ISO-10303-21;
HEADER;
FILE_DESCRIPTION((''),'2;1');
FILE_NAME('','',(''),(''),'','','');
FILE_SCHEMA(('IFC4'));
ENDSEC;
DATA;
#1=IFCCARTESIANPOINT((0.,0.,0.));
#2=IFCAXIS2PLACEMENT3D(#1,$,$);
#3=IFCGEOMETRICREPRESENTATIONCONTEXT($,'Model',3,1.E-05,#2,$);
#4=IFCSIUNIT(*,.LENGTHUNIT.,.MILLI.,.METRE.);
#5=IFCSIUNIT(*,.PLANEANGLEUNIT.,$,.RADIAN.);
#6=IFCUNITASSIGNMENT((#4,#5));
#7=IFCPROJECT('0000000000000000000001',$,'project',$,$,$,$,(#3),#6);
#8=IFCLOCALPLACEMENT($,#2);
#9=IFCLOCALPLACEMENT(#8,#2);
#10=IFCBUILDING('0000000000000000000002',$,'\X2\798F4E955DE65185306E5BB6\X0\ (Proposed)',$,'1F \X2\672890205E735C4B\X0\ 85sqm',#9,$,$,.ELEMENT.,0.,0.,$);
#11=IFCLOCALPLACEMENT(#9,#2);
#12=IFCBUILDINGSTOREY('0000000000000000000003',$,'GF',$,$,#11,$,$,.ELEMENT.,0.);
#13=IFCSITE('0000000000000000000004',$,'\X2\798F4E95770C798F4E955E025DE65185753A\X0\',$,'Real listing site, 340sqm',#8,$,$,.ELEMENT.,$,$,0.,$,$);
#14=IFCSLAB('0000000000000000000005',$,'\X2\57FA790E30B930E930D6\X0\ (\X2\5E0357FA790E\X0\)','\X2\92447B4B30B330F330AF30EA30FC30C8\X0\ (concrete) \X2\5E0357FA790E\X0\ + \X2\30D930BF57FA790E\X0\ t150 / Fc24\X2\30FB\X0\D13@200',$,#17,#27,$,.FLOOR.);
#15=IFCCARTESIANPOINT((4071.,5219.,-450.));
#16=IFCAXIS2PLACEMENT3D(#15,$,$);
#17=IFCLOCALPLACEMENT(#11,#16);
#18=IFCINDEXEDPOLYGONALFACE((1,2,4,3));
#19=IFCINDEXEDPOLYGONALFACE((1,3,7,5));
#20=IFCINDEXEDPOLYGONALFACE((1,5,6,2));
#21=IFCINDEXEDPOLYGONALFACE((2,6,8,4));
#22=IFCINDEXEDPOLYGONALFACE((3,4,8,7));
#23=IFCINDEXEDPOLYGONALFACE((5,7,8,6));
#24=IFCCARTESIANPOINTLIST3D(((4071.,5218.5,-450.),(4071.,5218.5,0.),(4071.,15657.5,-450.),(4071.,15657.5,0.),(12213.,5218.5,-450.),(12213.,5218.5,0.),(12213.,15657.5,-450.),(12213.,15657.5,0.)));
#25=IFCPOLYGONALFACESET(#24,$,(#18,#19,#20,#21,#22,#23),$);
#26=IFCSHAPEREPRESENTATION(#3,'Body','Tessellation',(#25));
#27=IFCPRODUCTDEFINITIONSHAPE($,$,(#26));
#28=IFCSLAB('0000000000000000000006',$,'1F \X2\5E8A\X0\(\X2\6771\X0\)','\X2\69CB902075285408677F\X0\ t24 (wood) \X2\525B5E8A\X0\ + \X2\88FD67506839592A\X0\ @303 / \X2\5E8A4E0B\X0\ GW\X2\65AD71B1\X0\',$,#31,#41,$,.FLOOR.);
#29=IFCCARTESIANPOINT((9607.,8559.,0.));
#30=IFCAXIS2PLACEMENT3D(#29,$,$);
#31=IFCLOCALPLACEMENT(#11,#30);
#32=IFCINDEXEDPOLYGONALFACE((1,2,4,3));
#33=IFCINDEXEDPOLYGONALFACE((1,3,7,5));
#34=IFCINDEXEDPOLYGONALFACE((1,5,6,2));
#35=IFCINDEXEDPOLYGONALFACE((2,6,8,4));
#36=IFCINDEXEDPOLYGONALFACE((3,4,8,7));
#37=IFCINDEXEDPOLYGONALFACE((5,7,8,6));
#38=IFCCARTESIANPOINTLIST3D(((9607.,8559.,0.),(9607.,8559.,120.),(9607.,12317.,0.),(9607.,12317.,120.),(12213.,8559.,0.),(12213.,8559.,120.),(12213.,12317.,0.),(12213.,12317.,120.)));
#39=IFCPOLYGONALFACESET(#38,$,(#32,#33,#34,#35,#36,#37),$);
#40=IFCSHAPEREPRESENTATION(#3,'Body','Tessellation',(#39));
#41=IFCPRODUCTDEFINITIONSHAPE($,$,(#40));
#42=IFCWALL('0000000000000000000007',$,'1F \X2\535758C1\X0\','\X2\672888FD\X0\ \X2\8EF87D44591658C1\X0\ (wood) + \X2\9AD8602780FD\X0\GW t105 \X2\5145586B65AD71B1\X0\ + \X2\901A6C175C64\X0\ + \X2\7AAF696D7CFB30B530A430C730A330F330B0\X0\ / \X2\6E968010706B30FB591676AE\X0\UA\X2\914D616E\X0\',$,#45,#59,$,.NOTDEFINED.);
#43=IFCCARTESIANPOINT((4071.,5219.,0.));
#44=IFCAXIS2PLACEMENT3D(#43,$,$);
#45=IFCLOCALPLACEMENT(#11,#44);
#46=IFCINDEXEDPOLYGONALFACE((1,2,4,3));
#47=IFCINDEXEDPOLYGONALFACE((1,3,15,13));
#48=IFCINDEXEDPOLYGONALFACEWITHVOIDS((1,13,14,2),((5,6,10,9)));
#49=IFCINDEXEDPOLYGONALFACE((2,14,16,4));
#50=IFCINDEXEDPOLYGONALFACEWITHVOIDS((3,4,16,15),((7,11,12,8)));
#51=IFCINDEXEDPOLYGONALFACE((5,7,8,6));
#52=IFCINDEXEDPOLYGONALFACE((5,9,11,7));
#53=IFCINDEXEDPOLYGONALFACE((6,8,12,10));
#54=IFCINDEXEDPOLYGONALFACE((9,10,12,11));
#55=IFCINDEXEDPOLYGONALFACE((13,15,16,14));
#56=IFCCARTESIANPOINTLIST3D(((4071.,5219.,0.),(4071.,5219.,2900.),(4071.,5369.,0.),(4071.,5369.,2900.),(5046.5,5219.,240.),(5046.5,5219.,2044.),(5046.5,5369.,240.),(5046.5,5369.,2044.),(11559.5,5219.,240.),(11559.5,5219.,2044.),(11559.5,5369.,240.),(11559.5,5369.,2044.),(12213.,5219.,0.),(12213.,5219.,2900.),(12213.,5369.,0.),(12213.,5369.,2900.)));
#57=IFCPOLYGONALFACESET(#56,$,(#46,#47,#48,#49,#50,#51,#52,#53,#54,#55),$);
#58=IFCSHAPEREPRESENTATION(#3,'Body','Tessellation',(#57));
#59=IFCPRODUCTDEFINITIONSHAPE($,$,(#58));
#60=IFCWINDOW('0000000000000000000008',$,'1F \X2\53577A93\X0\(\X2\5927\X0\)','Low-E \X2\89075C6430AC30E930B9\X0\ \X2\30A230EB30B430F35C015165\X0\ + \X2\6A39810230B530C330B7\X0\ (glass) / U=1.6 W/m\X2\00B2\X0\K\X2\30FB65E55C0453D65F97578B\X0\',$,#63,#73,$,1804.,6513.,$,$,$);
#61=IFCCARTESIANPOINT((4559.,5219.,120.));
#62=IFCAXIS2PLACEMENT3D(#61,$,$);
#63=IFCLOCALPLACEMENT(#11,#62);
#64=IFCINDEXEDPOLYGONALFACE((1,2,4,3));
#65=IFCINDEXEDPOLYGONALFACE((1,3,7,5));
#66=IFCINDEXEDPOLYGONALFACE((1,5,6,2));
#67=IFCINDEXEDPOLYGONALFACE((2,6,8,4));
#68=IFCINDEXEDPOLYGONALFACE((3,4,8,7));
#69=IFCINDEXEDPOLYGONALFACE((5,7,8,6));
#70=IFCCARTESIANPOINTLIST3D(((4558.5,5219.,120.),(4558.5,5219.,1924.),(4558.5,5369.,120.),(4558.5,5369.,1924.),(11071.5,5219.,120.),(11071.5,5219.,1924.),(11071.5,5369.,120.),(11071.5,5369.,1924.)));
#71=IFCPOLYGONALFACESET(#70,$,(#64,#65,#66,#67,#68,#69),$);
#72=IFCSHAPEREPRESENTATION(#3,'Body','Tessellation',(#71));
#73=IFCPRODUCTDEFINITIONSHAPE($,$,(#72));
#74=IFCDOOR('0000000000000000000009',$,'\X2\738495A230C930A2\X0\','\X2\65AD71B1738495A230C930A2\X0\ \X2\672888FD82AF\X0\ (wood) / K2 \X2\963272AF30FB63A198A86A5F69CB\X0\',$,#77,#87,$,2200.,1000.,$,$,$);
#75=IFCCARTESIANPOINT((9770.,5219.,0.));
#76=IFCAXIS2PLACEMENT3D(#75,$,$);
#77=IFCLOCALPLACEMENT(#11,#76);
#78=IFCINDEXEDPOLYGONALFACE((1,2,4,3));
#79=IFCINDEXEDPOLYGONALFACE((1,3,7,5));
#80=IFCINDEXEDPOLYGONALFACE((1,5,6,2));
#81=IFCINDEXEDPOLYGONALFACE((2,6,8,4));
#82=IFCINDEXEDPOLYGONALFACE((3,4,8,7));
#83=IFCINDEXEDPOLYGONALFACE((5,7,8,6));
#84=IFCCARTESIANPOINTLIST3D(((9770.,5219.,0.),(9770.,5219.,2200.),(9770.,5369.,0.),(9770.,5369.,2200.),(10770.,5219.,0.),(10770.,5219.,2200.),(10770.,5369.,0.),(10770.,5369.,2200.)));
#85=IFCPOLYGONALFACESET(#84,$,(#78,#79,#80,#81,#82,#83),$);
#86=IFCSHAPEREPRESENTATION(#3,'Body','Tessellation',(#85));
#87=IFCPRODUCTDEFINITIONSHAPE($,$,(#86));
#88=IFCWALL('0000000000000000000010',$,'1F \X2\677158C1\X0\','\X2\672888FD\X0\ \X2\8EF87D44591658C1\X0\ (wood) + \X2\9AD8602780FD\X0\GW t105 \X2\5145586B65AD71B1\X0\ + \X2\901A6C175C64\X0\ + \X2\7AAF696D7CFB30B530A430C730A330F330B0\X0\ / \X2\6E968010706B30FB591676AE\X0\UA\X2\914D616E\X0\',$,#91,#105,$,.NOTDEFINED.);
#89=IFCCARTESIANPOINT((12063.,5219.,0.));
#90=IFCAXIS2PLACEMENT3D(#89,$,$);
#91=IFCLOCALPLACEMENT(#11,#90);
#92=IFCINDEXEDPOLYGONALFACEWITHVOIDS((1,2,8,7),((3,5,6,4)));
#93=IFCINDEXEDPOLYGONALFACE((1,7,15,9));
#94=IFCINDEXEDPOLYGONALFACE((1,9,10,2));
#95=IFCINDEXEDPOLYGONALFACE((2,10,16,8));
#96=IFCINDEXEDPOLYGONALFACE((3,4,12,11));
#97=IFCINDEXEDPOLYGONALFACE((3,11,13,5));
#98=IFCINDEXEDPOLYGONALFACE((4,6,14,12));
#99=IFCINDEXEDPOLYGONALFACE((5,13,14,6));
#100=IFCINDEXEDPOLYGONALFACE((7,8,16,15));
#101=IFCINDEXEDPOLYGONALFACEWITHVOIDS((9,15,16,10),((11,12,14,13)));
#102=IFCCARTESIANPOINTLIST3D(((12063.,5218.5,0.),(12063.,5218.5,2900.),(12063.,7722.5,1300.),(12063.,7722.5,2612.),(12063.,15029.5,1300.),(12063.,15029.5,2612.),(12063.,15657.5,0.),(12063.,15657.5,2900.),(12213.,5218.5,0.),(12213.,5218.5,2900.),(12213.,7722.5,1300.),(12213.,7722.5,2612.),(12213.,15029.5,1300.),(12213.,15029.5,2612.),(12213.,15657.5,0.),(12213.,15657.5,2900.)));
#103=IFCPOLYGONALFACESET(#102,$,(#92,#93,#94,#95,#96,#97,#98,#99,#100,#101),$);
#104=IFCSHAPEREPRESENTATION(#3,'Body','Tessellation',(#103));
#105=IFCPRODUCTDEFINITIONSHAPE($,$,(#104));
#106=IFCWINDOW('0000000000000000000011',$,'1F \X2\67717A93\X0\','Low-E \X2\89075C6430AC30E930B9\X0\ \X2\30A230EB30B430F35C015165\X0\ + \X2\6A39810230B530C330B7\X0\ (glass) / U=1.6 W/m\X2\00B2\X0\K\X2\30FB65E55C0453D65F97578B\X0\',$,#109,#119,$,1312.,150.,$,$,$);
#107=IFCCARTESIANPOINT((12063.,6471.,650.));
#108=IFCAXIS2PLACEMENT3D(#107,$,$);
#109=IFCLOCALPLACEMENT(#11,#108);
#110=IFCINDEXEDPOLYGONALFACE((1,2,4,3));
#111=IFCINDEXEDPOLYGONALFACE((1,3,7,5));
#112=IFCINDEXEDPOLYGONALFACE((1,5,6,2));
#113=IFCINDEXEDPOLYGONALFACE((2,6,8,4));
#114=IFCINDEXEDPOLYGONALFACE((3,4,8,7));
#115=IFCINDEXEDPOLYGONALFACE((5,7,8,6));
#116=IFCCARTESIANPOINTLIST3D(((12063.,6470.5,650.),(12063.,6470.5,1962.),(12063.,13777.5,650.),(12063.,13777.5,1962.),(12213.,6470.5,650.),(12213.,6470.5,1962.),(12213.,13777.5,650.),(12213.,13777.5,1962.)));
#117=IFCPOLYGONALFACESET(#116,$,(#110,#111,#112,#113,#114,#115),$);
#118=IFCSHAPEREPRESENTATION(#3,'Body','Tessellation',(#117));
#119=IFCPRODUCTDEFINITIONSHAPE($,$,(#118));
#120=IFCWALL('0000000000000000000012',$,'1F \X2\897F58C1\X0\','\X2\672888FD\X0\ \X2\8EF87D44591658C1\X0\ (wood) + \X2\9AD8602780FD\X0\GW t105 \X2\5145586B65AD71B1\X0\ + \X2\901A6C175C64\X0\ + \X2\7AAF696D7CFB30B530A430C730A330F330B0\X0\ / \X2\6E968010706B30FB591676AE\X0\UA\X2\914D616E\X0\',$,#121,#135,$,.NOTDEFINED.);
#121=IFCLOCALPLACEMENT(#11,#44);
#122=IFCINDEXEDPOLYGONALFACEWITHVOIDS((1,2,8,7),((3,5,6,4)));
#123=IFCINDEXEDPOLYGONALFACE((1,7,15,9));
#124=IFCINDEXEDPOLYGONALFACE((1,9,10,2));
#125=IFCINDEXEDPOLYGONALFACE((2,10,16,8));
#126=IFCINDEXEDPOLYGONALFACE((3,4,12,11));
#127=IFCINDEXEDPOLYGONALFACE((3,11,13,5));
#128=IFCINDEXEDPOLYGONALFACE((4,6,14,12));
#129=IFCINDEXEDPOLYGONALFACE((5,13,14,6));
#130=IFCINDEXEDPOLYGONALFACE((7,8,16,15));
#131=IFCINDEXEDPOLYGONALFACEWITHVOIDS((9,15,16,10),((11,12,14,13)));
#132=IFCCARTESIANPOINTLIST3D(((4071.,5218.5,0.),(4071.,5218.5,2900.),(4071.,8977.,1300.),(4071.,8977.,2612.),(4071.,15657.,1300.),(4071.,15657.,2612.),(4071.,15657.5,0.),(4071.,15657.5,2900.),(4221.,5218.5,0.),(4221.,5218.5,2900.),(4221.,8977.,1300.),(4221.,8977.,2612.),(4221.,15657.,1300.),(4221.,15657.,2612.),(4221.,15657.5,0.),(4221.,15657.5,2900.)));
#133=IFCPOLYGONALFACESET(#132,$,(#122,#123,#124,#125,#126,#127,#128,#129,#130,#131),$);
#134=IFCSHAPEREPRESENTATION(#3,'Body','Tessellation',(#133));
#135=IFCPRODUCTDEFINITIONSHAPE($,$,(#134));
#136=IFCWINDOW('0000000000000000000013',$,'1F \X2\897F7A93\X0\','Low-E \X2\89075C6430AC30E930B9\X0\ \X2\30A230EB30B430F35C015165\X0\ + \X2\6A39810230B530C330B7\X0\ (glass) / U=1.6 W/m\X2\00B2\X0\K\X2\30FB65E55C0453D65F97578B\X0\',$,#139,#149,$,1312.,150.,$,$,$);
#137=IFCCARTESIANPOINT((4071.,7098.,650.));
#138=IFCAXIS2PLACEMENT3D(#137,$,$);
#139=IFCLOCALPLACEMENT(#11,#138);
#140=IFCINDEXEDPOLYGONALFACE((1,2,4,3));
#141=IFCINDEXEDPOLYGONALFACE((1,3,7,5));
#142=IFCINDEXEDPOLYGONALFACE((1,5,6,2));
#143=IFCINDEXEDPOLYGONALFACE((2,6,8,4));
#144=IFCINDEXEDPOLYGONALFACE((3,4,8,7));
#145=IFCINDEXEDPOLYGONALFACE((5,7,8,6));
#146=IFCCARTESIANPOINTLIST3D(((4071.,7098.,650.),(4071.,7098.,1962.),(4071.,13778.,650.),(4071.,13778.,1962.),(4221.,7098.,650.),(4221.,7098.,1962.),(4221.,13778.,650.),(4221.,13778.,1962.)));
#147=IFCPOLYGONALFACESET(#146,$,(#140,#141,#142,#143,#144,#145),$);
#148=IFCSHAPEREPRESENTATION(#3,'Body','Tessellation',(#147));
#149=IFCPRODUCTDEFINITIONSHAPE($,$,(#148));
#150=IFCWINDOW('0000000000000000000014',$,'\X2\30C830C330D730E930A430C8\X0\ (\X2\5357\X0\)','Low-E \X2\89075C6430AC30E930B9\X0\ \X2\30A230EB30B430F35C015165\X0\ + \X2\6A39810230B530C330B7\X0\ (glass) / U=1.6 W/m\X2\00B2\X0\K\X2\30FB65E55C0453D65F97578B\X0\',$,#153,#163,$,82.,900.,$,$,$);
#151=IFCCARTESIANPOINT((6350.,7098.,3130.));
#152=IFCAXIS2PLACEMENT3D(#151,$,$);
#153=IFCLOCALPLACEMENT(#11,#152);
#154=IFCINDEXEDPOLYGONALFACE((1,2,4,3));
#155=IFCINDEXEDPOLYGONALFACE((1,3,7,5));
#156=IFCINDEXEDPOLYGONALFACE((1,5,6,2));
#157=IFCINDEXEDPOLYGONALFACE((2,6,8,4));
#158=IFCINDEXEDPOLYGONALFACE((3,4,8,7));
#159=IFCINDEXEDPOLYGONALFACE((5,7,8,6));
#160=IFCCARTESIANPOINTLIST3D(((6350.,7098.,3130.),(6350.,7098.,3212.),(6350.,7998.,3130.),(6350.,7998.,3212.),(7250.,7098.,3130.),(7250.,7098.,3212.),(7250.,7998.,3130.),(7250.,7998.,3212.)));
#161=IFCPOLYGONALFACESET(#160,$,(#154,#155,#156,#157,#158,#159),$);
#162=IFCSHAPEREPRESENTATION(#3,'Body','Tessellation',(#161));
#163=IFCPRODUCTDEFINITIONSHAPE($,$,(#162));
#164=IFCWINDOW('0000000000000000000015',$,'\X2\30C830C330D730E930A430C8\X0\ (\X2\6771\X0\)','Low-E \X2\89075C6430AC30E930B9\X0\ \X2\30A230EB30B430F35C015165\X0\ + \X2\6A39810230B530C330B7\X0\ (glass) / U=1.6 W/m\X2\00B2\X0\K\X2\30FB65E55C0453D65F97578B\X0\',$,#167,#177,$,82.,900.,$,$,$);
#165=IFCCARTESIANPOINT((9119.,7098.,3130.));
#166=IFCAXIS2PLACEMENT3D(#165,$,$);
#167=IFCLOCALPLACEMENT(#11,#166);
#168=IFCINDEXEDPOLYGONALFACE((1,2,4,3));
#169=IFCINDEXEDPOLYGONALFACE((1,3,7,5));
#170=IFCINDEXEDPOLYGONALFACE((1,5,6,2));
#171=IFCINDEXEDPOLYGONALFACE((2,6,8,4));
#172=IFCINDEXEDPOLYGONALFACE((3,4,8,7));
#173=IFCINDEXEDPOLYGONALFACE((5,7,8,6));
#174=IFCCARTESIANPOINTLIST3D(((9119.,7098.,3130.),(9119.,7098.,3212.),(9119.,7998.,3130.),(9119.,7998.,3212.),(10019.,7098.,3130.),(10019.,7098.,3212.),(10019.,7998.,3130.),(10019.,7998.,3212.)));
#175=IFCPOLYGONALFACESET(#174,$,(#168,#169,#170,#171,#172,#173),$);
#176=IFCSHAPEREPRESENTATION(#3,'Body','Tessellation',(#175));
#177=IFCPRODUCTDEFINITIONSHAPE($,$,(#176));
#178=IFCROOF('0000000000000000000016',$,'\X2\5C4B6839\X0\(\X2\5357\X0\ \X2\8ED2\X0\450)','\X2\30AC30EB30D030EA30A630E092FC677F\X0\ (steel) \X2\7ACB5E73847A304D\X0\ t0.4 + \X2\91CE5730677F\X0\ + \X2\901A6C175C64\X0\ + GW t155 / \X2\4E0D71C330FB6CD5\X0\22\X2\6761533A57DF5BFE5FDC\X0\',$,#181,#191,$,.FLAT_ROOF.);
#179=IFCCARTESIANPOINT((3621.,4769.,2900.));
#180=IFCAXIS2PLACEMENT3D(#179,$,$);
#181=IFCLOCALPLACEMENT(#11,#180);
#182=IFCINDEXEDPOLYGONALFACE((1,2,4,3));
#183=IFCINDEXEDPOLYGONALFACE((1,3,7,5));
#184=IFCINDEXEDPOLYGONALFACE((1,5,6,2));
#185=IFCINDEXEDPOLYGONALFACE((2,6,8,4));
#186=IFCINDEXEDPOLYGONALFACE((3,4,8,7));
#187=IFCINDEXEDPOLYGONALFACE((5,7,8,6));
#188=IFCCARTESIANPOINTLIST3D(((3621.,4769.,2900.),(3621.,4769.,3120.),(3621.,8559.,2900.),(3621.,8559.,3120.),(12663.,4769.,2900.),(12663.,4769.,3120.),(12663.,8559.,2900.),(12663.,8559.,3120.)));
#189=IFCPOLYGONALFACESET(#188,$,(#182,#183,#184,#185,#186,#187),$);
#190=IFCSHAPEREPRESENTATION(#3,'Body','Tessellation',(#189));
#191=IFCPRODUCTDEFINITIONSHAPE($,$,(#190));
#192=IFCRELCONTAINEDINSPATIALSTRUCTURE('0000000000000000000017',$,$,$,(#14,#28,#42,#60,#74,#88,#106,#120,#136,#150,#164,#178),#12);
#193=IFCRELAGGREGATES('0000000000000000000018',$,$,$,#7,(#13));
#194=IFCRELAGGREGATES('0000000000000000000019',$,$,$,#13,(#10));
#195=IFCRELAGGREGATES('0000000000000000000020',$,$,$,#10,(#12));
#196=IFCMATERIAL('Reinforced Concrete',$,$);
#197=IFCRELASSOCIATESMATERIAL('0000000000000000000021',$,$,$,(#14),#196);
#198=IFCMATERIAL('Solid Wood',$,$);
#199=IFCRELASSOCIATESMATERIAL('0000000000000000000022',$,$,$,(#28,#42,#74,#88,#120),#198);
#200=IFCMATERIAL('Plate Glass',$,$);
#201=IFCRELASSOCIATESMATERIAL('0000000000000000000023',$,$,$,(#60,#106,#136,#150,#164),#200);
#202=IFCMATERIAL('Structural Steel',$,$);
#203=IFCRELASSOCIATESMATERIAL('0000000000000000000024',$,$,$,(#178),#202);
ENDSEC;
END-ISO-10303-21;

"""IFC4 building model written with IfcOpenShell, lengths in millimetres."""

from ifc_helpers import new_model, si_unit, frame, frame_2d, origin, place, context, project, spatial, rectangle, extrude, material, element, fill, save


model = new_model("IFC4")

# Units and contexts
model_context = context("Model", 3, precision=1e-05, world=origin())
ifc_project = project(units=[si_unit("LENGTHUNIT", "METRE", prefix="MILLI"), si_unit("PLANEANGLEUNIT", "RADIAN")], contexts=[model_context])

# Site, building, storey
site_placement = place(None, origin())
site = spatial("IfcSite", under=ifc_project, at=site_placement, Name="福井県福井市左内町", ObjectType="Real listing site, 340sqm", CompositionType="ELEMENT", RefElevation=0.0)
building_placement = place(site_placement, origin())
building = spatial("IfcBuilding", under=site, at=building_placement, Name="福井左内の家 (Proposed)", ObjectType="1F 木造平屋 85sqm", CompositionType="ELEMENT", ElevationOfRefHeight=0.0, ElevationOfTerrain=0.0)
storey_placement = place(building_placement, origin())
storey = spatial("IfcBuildingStorey", under=building, at=storey_placement, Name="GF", CompositionType="ELEMENT", Elevation=0.0)

# Slabs
ifc_material_1 = material(Name="Reinforced Concrete")
slab_1_placement = place(storey_placement, frame((4071.0, 5219.0, -450.0)))
element("IfcSlab", 1, at=slab_1_placement, inside=storey, material=ifc_material_1, Name="基礎スラブ (布基礎)", Description="鉄筋コンクリート (concrete) 布基礎 + ベタ基礎 t150 / Fc24・D13@200", PredefinedType="FLOOR", context=model_context, shape_type="SweptSolid", body=[
    extrude(rectangle(XDim=8142.0, YDim=10439.0, at=frame_2d((4071.0, 5219.0))), frame((4071.0, 5219.0, -450.0)), (0.0, 0.0, 1.0), 450.0),
])
ifc_material_2 = material(Name="Solid Wood")
slab_2_placement = place(storey_placement, frame((9607.0, 8559.0, 0.0)))
element("IfcSlab", 2, at=slab_2_placement, inside=storey, material=ifc_material_2, Name="1F 床(東)", Description="構造用合板 t24 (wood) 剛床 + 製材根太 @303 / 床下 GW断熱", PredefinedType="FLOOR", context=model_context, shape_type="SweptSolid", body=[
    extrude(rectangle(XDim=2606.0, YDim=3758.0, at=frame_2d((1303.0, 1879.0))), frame((9607.0, 8559.0, 0.0)), (0.0, 0.0, 1.0), 120.0),
])

# Wall, openings, window, door
wall_1_placement = place(storey_placement, frame((4071.0, 5219.0, 0.0)))
wall_1 = element("IfcWall", 3, at=wall_1_placement, inside=storey, material=ifc_material_2, Name="1F 南壁", Description="木製 軸組外壁 (wood) + 高性能GW t105 充填断熱 + 通気層 + 窯業系サイディング / 準耐火・外皮UA配慮", PredefinedType="NOTDEFINED", context=model_context, shape_type="SweptSolid", body=[
    extrude(rectangle(XDim=8142.0, YDim=150.0, at=frame_2d((4071.0, 75.0))), frame((4071.0, 5219.0, 0.0)), (0.0, 0.0, 1.0), 2900.0),
])
opening_1_placement = place(storey_placement, frame((4559.0, 5219.0, 120.0)))
opening_1 = element("IfcOpeningElement", 4, at=opening_1_placement, cuts=wall_1, PredefinedType="NOTDEFINED", context=model_context, shape_type="SweptSolid", body=[
    extrude(rectangle(XDim=6513.0, YDim=150.0, at=frame_2d((3256.0, 75.0))), frame((4559.0, 5219.0, 120.0)), (0.0, 0.0, 1.0), 1804.0),
])
opening_2_placement = place(storey_placement, frame((9770.0, 5219.0, 0.0)))
opening_2 = element("IfcOpeningElement", 5, at=opening_2_placement, cuts=wall_1, PredefinedType="NOTDEFINED", context=model_context, shape_type="SweptSolid", body=[
    extrude(rectangle(XDim=1000.0, YDim=150.0, at=frame_2d((500.0, 75.0))), frame((9770.0, 5219.0, 0.0)), (0.0, 0.0, 1.0), 2200.0),
])
ifc_material_3 = material(Name="Plate Glass")
window_1_placement = place(storey_placement, frame((4559.0, 5219.0, 120.0)))
window_1 = element("IfcWindow", 6, at=window_1_placement, inside=storey, material=ifc_material_3, Name="1F 南窓(大)", Description="Low-E 複層ガラス アルゴン封入 + 樹脂サッシ (glass) / U=1.6 W/m²K・日射取得型", OverallHeight=1804.0, OverallWidth=6513.0, context=model_context, shape_type="SweptSolid", body=[
    extrude(rectangle(XDim=6513.0, YDim=150.0, at=frame_2d((3256.0, 75.0))), frame((4559.0, 5219.0, 120.0)), (0.0, 0.0, 1.0), 1804.0),
])
fill(opening_1, window_1)
door_placement = place(storey_placement, frame((9770.0, 5219.0, 0.0)))
door = element("IfcDoor", 7, at=door_placement, inside=storey, material=ifc_material_2, Name="玄関ドア", Description="断熱玄関ドア 木製芯 (wood) / K2 防犯・採風機構", OverallHeight=2200.0, OverallWidth=1000.0, context=model_context, shape_type="SweptSolid", body=[
    extrude(rectangle(XDim=1000.0, YDim=150.0, at=frame_2d((500.0, 75.0))), frame((9770.0, 5219.0, 0.0)), (0.0, 0.0, 1.0), 2200.0),
])
fill(opening_2, door)

# Walls, openings, windows
wall_2_placement = place(storey_placement, frame((12063.0, 5219.0, 0.0)))
wall_2 = element("IfcWall", 8, at=wall_2_placement, inside=storey, material=ifc_material_2, Name="1F 東壁", Description="木製 軸組外壁 (wood) + 高性能GW t105 充填断熱 + 通気層 + 窯業系サイディング / 準耐火・外皮UA配慮", PredefinedType="NOTDEFINED", context=model_context, shape_type="SweptSolid", body=[
    extrude(rectangle(XDim=150.0, YDim=10439.0, at=frame_2d((75.0, 5219.0))), frame((12063.0, 5219.0, 0.0)), (0.0, 0.0, 1.0), 2900.0),
])
opening_3_placement = place(storey_placement, frame((12063.0, 6471.0, 650.0)))
opening_3 = element("IfcOpeningElement", 9, at=opening_3_placement, cuts=wall_2, PredefinedType="NOTDEFINED", context=model_context, shape_type="SweptSolid", body=[
    extrude(rectangle(XDim=150.0, YDim=7307.0, at=frame_2d((75.0, 3653.0))), frame((12063.0, 6471.0, 650.0)), (0.0, 0.0, 1.0), 1312.0),
])
window_2_placement = place(storey_placement, frame((12063.0, 6471.0, 650.0)))
window_2 = element("IfcWindow", 10, at=window_2_placement, inside=storey, material=ifc_material_3, Name="1F 東窓", Description="Low-E 複層ガラス アルゴン封入 + 樹脂サッシ (glass) / U=1.6 W/m²K・日射取得型", OverallHeight=1312.0, OverallWidth=150.0, context=model_context, shape_type="SweptSolid", body=[
    extrude(rectangle(XDim=150.0, YDim=7307.0, at=frame_2d((75.0, 3653.0))), frame((12063.0, 6471.0, 650.0)), (0.0, 0.0, 1.0), 1312.0),
])
fill(opening_3, window_2)
wall_3_placement = place(storey_placement, frame((4071.0, 5219.0, 0.0)))
wall_3 = element("IfcWall", 11, at=wall_3_placement, inside=storey, material=ifc_material_2, Name="1F 西壁", Description="木製 軸組外壁 (wood) + 高性能GW t105 充填断熱 + 通気層 + 窯業系サイディング / 準耐火・外皮UA配慮", PredefinedType="NOTDEFINED", context=model_context, shape_type="SweptSolid", body=[
    extrude(rectangle(XDim=150.0, YDim=10439.0, at=frame_2d((75.0, 5219.0))), frame((4071.0, 5219.0, 0.0)), (0.0, 0.0, 1.0), 2900.0),
])
opening_4_placement = place(storey_placement, frame((4071.0, 7098.0, 650.0)))
opening_4 = element("IfcOpeningElement", 12, at=opening_4_placement, cuts=wall_3, PredefinedType="NOTDEFINED", context=model_context, shape_type="SweptSolid", body=[
    extrude(rectangle(XDim=150.0, YDim=6680.0, at=frame_2d((75.0, 3340.0))), frame((4071.0, 7098.0, 650.0)), (0.0, 0.0, 1.0), 1312.0),
])
window_3_placement = place(storey_placement, frame((4071.0, 7098.0, 650.0)))
window_3 = element("IfcWindow", 13, at=window_3_placement, inside=storey, material=ifc_material_3, Name="1F 西窓", Description="Low-E 複層ガラス アルゴン封入 + 樹脂サッシ (glass) / U=1.6 W/m²K・日射取得型", OverallHeight=1312.0, OverallWidth=150.0, context=model_context, shape_type="SweptSolid", body=[
    extrude(rectangle(XDim=150.0, YDim=6680.0, at=frame_2d((75.0, 3340.0))), frame((4071.0, 7098.0, 650.0)), (0.0, 0.0, 1.0), 1312.0),
])
fill(opening_4, window_3)

# Windows
window_4_placement = place(storey_placement, frame((6350.0, 7098.0, 3130.0)))
element("IfcWindow", 14, at=window_4_placement, inside=storey, material=ifc_material_3, Name="トップライト (南)", Description="Low-E 複層ガラス アルゴン封入 + 樹脂サッシ (glass) / U=1.6 W/m²K・日射取得型", OverallHeight=82.0, OverallWidth=900.0, context=model_context, shape_type="SweptSolid", body=[
    extrude(rectangle(XDim=900.0, YDim=900.0, at=frame_2d((450.0, 450.0))), frame((6350.0, 7098.0, 3130.0)), (0.0, 0.0, 1.0), 82.0),
])
window_5_placement = place(storey_placement, frame((9119.0, 7098.0, 3130.0)))
element("IfcWindow", 15, at=window_5_placement, inside=storey, material=ifc_material_3, Name="トップライト (東)", Description="Low-E 複層ガラス アルゴン封入 + 樹脂サッシ (glass) / U=1.6 W/m²K・日射取得型", OverallHeight=82.0, OverallWidth=900.0, context=model_context, shape_type="SweptSolid", body=[
    extrude(rectangle(XDim=900.0, YDim=900.0, at=frame_2d((450.0, 450.0))), frame((9119.0, 7098.0, 3130.0)), (0.0, 0.0, 1.0), 82.0),
])

# Roof
ifc_material_4 = material(Name="Structural Steel")
roof_placement = place(storey_placement, frame((3621.0, 4769.0, 2900.0)))
element("IfcRoof", 16, at=roof_placement, inside=storey, material=ifc_material_4, Name="屋根(南 軒450)", Description="ガルバリウム鋼板 (steel) 立平葺き t0.4 + 野地板 + 通気層 + GW t155 / 不燃・法22条区域対応", PredefinedType="FLAT_ROOF", context=model_context, shape_type="SweptSolid", body=[
    extrude(rectangle(XDim=9042.0, YDim=3790.0, at=frame_2d((4521.0, 1895.0))), frame((3621.0, 4769.0, 2900.0)), (0.0, 0.0, 1.0), 220.0),
])

save(model, "model.ifc")
